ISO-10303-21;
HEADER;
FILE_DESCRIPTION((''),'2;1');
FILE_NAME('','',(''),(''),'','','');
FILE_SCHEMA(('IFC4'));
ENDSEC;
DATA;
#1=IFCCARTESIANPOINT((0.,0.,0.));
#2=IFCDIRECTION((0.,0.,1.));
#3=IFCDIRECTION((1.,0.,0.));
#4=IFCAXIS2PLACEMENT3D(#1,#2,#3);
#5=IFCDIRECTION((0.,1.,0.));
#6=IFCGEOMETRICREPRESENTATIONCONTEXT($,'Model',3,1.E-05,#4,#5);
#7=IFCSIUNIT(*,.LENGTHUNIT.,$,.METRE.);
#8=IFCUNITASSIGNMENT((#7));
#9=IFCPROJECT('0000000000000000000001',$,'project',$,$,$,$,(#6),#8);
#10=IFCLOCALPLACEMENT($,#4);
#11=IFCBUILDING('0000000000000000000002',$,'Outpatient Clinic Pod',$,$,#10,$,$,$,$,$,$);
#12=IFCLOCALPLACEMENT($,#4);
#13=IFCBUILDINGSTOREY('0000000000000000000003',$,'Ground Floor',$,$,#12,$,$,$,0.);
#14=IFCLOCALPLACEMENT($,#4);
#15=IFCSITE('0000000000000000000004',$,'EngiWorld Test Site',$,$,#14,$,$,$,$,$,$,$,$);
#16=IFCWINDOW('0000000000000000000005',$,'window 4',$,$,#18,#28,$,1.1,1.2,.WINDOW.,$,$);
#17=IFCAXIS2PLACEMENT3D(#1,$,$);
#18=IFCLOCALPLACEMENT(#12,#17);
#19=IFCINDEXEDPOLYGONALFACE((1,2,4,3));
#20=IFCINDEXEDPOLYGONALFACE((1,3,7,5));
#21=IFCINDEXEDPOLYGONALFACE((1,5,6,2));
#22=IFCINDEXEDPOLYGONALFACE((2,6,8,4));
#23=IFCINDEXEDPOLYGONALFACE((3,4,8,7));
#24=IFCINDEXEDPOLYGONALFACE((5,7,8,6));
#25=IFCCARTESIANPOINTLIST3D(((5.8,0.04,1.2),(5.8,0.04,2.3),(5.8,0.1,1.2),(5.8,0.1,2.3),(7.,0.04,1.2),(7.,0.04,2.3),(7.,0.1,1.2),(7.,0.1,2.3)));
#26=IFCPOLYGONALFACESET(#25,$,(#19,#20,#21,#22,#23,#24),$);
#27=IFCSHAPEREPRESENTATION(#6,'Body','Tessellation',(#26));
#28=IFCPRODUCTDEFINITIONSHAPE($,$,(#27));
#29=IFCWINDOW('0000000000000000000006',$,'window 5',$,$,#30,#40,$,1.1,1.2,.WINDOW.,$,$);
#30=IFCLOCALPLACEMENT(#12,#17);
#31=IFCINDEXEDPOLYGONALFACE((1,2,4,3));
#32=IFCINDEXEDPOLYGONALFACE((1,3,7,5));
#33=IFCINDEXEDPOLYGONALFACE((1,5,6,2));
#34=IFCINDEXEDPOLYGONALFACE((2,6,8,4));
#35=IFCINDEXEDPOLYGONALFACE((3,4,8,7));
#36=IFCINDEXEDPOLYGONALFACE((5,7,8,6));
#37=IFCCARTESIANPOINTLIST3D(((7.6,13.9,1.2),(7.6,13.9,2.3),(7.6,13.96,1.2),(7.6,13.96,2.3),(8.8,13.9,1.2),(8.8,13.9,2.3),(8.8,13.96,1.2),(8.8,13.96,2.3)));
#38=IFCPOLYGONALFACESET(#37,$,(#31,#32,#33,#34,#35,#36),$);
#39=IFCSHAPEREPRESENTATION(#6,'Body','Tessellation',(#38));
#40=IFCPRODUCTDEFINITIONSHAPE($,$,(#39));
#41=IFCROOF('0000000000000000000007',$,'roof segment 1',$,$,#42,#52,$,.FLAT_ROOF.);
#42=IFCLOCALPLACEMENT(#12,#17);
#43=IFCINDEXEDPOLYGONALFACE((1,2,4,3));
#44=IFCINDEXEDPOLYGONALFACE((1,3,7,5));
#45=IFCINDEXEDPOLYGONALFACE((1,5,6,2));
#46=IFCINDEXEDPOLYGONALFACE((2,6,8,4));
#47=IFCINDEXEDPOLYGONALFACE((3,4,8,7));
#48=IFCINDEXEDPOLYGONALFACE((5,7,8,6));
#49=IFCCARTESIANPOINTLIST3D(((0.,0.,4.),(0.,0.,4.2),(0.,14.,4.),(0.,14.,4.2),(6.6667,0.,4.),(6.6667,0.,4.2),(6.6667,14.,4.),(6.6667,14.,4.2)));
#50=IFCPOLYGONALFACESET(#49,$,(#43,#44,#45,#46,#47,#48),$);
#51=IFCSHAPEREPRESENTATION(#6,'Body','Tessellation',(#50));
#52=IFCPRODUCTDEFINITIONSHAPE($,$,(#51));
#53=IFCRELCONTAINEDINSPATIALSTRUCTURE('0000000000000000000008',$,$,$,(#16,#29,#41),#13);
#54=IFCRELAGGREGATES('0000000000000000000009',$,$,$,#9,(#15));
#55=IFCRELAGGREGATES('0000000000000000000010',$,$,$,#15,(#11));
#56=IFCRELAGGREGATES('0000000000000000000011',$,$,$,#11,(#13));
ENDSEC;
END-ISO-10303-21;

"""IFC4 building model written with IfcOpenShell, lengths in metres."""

from ifc_helpers import new_model, si_unit, direction, frame, origin_with_axes, origin_2d_with_axis, place, context, project, spatial, rectangle, extrude, element, save


model = new_model("IFC4")

# Units and contexts
model_context = context("Model", 3, precision=1e-05, world=origin_with_axes(), true_north=direction((0.0, 1.0, 0.0)))
ifc_project = project(units=[si_unit("LENGTHUNIT", "METRE")], contexts=[model_context])

# Site, building, storey
site_placement = place(None, origin_with_axes())
site = spatial("IfcSite", under=ifc_project, at=site_placement, Name="EngiWorld Test Site")
building_placement = place(None, origin_with_axes())
building = spatial("IfcBuilding", under=site, at=building_placement, Name="Outpatient Clinic Pod")
storey_placement = place(None, origin_with_axes())
storey = spatial("IfcBuildingStorey", under=building, at=storey_placement, Name="Ground Floor", Elevation=0.0)

# Windows
for number, where, z_axis, x_axis, name in (
    (1, (6.4, 0.07, 1.2), (0.0, 0.0, 1.0), (1.0, 0.0, 0.0), "window 4"),
    (2, (8.2, 13.93, 1.2), (0.0, 0.0, 1.0), (1.0, 0.0, 0.0), "window 5"),
):
    element("IfcWindow", number, at=place(None, frame(where, z_axis=z_axis, x_axis=x_axis)), inside=storey, Name=name, OverallHeight=1.1, OverallWidth=1.2, PredefinedType="WINDOW", context=model_context, shape_type="SweptSolid", body=[
        extrude(rectangle(XDim=1.2, YDim=0.06, at=origin_2d_with_axis()), origin_with_axes(), (0.0, 0.0, 1.0), 1.1),
    ])

# Roof
roof_placement = place(None, frame((3.3333, 7.0, 4.0), z_axis=(0.0, 0.0, 1.0), x_axis=(1.0, 0.0, 0.0)))
element("IfcRoof", 3, at=roof_placement, inside=storey, Name="roof segment 1", PredefinedType="FLAT_ROOF", context=model_context, shape_type="SweptSolid", body=[
    extrude(rectangle(XDim=6.6667, YDim=14.0, at=origin_2d_with_axis()), origin_with_axes(), (0.0, 0.0, 1.0), 0.2),
])

save(model, "model.ifc")
